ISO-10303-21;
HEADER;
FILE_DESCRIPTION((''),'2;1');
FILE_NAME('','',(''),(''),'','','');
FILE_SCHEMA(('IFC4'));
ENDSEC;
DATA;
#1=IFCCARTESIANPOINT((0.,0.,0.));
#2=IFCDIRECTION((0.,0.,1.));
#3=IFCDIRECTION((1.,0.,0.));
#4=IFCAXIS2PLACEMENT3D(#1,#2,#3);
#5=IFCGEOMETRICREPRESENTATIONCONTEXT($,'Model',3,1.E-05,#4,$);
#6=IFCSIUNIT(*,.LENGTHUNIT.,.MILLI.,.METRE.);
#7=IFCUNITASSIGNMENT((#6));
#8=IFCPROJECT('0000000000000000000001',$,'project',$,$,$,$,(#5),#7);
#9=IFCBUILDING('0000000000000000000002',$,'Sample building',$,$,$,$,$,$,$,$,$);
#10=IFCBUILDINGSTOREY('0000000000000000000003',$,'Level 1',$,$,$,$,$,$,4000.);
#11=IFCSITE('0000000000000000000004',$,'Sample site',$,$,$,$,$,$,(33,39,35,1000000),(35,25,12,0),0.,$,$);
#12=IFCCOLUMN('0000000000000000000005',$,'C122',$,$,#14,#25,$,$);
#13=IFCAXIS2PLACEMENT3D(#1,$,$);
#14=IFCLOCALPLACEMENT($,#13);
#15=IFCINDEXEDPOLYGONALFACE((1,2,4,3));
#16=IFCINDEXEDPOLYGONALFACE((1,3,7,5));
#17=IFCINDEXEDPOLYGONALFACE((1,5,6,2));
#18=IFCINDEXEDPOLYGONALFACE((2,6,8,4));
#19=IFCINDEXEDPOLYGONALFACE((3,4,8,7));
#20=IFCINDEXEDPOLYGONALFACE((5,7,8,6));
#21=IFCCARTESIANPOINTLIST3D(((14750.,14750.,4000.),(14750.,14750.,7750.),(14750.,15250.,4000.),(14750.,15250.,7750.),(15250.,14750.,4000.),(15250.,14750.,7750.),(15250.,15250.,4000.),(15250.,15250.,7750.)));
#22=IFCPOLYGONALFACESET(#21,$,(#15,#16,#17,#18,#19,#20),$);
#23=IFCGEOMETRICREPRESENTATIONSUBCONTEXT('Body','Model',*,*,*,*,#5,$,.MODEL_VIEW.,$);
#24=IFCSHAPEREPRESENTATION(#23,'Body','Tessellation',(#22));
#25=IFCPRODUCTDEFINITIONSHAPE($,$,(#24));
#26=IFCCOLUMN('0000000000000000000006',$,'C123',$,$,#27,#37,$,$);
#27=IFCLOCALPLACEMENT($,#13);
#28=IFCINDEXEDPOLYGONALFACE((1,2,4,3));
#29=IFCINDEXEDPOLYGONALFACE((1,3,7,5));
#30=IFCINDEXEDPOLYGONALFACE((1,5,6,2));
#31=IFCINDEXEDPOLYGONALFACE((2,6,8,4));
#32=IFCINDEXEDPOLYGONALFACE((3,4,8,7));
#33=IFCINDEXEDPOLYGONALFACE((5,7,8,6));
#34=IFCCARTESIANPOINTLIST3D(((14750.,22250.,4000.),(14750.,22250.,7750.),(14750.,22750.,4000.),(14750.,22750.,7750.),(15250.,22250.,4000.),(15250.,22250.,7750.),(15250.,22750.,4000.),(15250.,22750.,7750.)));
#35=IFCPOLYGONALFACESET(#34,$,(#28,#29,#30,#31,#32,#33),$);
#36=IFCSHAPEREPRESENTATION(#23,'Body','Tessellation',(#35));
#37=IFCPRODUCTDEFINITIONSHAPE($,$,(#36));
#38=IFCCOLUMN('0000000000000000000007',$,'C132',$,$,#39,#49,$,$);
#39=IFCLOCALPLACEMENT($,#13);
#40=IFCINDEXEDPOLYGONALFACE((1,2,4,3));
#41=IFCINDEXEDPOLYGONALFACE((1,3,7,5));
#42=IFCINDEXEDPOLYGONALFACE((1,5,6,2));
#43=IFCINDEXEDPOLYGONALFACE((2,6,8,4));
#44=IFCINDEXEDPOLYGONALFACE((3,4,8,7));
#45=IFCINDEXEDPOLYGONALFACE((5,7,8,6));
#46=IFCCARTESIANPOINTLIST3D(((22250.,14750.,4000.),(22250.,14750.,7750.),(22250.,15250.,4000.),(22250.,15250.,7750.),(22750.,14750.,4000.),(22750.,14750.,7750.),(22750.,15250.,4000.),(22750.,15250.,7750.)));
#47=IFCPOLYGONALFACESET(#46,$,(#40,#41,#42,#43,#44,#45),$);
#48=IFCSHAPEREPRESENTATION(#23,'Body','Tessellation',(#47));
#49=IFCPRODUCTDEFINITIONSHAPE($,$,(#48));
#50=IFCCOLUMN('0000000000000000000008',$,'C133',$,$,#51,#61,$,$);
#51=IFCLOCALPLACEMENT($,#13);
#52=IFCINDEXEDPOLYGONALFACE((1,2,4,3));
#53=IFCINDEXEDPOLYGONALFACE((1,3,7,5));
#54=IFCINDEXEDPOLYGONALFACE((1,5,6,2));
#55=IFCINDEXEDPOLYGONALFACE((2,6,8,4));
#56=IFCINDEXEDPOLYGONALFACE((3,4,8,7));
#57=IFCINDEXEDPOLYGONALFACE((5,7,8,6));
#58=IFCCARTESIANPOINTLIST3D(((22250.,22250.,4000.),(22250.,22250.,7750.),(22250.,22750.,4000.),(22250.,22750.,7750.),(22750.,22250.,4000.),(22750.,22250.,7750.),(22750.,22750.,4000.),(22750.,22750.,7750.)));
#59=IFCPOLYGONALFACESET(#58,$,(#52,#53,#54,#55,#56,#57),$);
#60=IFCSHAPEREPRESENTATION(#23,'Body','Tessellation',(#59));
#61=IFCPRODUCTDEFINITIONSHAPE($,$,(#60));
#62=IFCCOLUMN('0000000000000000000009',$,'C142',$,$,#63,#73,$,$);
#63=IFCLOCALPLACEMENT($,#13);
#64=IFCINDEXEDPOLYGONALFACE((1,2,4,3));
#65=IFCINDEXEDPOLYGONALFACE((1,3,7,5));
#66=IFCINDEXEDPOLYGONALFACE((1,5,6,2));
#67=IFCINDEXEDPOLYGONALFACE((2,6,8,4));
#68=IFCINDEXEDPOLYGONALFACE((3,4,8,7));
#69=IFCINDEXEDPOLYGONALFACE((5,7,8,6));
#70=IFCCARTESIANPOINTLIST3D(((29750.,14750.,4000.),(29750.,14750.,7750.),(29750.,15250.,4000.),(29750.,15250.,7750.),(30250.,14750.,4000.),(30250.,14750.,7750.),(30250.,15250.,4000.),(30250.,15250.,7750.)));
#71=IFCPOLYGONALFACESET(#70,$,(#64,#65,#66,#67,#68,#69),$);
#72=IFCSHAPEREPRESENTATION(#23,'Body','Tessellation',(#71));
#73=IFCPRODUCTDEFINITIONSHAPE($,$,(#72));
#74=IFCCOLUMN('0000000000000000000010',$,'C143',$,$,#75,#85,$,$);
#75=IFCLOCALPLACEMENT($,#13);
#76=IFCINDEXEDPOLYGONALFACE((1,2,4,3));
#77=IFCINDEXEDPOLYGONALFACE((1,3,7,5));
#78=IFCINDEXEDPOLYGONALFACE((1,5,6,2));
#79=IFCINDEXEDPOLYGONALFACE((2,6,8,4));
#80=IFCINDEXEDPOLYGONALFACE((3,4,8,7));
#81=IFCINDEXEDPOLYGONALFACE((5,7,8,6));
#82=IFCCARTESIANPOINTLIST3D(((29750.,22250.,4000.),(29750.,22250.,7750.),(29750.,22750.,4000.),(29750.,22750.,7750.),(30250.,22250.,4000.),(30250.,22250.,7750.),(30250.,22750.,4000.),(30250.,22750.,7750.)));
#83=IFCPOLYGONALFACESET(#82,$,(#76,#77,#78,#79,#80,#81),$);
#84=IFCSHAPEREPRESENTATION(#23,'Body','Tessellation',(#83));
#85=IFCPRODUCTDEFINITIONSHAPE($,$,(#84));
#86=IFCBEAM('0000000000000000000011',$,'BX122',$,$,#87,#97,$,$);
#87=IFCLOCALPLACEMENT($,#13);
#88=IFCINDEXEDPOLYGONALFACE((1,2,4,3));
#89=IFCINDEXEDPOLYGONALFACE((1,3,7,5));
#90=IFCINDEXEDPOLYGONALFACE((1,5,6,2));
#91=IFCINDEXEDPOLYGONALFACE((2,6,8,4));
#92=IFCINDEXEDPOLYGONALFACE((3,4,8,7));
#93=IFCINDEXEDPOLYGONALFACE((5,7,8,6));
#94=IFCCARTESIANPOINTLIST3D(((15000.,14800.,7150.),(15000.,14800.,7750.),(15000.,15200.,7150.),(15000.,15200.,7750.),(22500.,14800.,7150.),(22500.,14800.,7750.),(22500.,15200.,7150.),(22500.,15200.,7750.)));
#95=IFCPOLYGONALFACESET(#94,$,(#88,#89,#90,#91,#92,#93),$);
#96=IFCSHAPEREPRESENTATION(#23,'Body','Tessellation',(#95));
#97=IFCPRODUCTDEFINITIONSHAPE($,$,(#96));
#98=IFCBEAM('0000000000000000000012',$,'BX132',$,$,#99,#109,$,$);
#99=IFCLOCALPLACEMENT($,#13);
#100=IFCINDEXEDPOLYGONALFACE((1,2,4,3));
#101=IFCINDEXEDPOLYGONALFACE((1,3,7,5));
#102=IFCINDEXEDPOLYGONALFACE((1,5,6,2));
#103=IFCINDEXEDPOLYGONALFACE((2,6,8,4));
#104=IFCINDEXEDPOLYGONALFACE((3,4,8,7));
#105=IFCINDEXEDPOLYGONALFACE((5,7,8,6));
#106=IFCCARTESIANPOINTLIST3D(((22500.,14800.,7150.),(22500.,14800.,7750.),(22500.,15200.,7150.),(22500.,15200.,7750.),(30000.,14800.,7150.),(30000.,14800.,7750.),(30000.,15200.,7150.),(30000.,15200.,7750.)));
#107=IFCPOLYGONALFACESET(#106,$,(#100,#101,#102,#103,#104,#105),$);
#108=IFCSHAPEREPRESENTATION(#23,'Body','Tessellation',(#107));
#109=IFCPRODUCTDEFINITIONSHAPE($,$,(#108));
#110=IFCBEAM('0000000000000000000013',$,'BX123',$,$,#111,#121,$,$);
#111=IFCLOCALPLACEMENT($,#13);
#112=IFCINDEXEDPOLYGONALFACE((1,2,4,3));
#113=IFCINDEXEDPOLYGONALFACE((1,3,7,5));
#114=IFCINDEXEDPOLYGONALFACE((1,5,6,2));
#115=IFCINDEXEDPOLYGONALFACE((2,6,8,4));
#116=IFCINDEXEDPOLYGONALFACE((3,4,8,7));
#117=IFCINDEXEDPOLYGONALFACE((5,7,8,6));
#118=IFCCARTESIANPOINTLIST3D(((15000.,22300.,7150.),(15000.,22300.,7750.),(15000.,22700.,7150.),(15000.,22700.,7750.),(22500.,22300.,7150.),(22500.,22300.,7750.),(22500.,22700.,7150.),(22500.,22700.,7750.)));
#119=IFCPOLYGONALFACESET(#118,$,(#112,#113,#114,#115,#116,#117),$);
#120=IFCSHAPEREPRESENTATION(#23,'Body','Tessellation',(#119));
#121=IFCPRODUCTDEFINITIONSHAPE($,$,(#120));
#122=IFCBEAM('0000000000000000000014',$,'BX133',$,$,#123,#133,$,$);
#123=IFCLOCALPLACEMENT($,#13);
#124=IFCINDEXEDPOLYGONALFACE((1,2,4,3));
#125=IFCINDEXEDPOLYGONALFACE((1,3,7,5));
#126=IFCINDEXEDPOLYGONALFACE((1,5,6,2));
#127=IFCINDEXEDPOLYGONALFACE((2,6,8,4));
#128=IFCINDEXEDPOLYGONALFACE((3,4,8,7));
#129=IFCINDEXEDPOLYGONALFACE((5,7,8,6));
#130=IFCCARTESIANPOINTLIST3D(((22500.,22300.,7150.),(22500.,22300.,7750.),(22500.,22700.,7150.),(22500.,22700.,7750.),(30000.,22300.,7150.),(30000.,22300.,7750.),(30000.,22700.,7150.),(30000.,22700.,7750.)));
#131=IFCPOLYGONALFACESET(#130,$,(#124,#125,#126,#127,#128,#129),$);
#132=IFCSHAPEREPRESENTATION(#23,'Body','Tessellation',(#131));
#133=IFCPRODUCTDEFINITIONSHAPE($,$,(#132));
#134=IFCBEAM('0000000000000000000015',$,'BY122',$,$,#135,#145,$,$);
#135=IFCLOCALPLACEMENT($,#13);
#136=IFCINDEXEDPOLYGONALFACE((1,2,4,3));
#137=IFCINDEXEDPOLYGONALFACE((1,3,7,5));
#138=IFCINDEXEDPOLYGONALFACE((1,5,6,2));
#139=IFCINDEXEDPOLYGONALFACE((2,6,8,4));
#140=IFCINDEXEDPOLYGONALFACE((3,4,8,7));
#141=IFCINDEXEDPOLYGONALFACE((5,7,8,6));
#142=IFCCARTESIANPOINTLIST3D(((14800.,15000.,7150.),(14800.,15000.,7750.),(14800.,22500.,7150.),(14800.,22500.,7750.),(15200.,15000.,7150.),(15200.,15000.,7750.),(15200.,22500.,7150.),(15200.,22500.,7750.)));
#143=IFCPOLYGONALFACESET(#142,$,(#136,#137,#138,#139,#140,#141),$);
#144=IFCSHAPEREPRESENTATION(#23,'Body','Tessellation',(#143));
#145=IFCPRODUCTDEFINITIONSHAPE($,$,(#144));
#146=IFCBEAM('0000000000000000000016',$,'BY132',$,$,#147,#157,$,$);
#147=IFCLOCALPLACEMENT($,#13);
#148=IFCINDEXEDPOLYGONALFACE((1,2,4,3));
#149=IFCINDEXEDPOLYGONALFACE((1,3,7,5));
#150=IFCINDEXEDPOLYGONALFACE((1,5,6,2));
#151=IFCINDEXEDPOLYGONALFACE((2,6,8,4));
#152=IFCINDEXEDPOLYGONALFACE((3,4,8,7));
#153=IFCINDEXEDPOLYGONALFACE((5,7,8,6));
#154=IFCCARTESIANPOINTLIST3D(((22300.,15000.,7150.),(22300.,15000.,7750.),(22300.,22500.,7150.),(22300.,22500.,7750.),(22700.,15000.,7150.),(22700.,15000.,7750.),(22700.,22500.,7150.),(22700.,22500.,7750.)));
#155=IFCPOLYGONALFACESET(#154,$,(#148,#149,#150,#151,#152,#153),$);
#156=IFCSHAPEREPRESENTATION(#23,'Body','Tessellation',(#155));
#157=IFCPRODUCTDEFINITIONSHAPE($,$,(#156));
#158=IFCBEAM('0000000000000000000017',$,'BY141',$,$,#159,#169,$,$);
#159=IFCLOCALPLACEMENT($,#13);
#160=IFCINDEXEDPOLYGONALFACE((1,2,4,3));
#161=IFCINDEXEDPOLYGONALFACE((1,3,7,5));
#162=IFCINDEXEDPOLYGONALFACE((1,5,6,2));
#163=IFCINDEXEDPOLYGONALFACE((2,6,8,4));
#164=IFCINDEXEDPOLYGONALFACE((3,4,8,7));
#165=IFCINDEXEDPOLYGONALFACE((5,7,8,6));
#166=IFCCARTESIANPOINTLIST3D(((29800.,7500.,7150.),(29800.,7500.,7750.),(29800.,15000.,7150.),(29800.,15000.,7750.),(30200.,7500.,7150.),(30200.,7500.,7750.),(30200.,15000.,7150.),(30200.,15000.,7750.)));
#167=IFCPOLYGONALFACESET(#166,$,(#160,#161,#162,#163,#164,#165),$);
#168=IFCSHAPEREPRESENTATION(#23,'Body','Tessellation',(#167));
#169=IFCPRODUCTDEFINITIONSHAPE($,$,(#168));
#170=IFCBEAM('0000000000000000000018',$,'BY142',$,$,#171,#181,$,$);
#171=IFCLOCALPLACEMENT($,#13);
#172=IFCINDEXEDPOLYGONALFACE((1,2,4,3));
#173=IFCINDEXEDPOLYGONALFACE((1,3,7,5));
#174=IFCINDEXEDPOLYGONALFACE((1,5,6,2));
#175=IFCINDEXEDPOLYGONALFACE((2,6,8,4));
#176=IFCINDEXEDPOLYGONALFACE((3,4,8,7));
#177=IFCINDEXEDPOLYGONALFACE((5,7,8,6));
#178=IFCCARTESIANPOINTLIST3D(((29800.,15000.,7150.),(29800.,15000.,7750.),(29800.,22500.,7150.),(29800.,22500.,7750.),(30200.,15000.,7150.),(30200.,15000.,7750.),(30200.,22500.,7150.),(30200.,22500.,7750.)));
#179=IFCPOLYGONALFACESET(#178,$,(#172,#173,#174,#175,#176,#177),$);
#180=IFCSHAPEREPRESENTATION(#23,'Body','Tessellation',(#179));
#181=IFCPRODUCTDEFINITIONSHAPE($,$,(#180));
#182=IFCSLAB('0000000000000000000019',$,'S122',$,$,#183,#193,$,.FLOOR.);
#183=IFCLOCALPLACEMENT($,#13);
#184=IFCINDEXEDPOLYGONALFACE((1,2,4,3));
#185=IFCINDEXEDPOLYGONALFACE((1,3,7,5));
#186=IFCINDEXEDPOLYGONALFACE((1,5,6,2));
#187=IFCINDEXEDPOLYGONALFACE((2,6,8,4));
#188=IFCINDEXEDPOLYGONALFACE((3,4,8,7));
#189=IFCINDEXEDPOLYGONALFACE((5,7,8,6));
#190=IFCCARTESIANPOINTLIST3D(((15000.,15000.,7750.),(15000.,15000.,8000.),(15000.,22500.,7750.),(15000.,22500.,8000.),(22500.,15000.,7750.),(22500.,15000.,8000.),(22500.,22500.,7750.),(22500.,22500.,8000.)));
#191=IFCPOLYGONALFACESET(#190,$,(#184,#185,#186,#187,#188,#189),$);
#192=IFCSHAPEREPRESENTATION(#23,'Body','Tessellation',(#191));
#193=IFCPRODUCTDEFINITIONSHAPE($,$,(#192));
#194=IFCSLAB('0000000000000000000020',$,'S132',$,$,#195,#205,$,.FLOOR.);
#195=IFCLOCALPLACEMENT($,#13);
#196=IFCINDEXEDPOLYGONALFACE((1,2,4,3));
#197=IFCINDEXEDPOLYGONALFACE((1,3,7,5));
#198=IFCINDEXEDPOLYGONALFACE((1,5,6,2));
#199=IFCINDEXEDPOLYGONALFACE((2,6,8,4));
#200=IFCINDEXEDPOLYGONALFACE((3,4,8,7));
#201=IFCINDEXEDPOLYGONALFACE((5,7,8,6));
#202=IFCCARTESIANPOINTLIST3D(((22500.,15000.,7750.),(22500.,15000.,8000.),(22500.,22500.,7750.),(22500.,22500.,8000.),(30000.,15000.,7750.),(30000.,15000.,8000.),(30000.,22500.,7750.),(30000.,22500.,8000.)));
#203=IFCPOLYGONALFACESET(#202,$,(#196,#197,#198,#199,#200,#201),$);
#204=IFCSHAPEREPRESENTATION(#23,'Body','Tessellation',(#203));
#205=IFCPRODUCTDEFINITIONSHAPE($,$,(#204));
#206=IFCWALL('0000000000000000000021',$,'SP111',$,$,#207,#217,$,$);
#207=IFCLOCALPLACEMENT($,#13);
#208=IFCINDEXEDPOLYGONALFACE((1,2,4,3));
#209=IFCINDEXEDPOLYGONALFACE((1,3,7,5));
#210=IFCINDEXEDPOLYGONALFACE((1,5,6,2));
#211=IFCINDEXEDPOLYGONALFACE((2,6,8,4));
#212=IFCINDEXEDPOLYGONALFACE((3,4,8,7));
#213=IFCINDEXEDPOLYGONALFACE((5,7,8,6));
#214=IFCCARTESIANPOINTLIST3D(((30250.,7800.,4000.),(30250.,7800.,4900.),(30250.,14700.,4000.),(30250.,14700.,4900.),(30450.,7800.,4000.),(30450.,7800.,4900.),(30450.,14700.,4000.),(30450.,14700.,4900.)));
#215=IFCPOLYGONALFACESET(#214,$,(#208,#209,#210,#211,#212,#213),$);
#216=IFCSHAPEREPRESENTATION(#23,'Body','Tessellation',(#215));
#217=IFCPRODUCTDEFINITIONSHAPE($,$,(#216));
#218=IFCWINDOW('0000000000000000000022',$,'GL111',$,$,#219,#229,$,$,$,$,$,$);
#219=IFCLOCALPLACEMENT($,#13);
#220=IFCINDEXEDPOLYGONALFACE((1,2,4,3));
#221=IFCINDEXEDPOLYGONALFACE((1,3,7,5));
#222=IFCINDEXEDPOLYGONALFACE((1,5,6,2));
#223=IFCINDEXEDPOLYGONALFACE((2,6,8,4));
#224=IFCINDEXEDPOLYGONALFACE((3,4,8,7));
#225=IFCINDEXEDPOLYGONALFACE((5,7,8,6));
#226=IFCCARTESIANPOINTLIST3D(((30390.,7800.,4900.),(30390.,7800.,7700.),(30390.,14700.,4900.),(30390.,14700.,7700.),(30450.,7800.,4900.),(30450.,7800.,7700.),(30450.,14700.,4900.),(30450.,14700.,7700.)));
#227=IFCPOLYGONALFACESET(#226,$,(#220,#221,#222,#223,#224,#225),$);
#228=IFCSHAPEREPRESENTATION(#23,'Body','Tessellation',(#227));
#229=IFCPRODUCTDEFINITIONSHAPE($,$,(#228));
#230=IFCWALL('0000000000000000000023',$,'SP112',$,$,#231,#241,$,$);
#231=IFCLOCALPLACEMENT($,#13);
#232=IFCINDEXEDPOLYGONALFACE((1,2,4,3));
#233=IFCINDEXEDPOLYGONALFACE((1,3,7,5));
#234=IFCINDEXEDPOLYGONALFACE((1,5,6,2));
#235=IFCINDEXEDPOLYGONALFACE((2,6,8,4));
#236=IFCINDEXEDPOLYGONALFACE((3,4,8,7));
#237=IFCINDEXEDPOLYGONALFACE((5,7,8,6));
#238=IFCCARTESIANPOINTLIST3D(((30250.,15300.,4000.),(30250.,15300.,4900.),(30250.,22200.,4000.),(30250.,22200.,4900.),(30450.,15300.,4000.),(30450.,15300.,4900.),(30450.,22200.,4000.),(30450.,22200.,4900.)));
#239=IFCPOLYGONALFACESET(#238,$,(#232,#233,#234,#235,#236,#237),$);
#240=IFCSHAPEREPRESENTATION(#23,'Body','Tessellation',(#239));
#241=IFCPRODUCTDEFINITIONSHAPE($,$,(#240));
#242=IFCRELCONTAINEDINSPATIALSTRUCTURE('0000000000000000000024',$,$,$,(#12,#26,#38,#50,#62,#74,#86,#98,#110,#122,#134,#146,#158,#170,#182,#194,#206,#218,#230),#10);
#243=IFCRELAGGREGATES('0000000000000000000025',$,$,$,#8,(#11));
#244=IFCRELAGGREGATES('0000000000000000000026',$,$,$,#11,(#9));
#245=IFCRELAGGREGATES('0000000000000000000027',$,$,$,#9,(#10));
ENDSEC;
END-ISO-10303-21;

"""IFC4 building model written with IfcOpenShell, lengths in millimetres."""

from ifc_helpers import new_model, si_unit, frame, origin_with_axes, place, context, subcontext, project, spatial, indexed_curve, outline, extrude, element, save


model = new_model("IFC4")

# Units and contexts
model_context = context("Model", 3, precision=1e-05, world=origin_with_axes())
body_context = subcontext(model_context, "Body", "Model", "MODEL_VIEW")
ifc_project = project(units=[si_unit("LENGTHUNIT", "METRE", prefix="MILLI")], contexts=[model_context])

# Site, building, storey
site = spatial("IfcSite", under=ifc_project, Name="Sample site", RefLatitude=(33, 39, 35, 1000000), RefLongitude=(35, 25, 12, 0), RefElevation=0.0)
building = spatial("IfcBuilding", under=site, Name="Sample building")
storey = spatial("IfcBuildingStorey", under=building, Name="Level 1", Elevation=4000.0)

# Columns
for number, where, z_axis, x_axis, name in (
    (1, (14750.0, 14750.0, 4000.0), (0.0, 0.0, 1.0), (1.0, 0.0, 0.0), "C122"),
    (2, (14750.0, 22250.0, 4000.0), (0.0, 0.0, 1.0), (1.0, 0.0, 0.0), "C123"),
    (3, (22250.0, 14750.0, 4000.0), (0.0, 0.0, 1.0), (1.0, 0.0, 0.0), "C132"),
    (4, (22250.0, 22250.0, 4000.0), (0.0, 0.0, 1.0), (1.0, 0.0, 0.0), "C133"),
    (5, (29750.0, 14750.0, 4000.0), (0.0, 0.0, 1.0), (1.0, 0.0, 0.0), "C142"),
    (6, (29750.0, 22250.0, 4000.0), (0.0, 0.0, 1.0), (1.0, 0.0, 0.0), "C143"),
):
    element("IfcColumn", number, at=place(None, frame(where, z_axis=z_axis, x_axis=x_axis)), inside=storey, Name=name, context=body_context, shape_type="SweptSolid", body=[
        extrude(outline(indexed_curve([(0.0, 0.0), (0.0, 500.0), (500.0, 500.0), (500.0, 0.0), (0.0, 0.0)], self_intersect=False)), origin_with_axes(), (0.0, 0.0, 1.0), 3750.0),
    ])

# Beams
for number, where, z_axis, x_axis, name in (
    (7, (15000.0, 14800.0, 7150.0), (0.0, 0.0, 1.0), (1.0, 0.0, 0.0), "BX122"),
    (8, (22500.0, 14800.0, 7150.0), (0.0, 0.0, 1.0), (1.0, 0.0, 0.0), "BX132"),
    (9, (15000.0, 22300.0, 7150.0), (0.0, 0.0, 1.0), (1.0, 0.0, 0.0), "BX123"),
    (10, (22500.0, 22300.0, 7150.0), (0.0, 0.0, 1.0), (1.0, 0.0, 0.0), "BX133"),
    (11, (15200.0, 15000.0, 7150.0), (0.0, 0.0, 1.0), (0.0, 1.0, 0.0), "BY122"),
    (12, (22700.0, 15000.0, 7150.0), (0.0, 0.0, 1.0), (0.0, 1.0, 0.0), "BY132"),
    (13, (30200.0, 7500.0, 7150.0), (0.0, 0.0, 1.0), (0.0, 1.0, 0.0), "BY141"),
    (14, (30200.0, 15000.0, 7150.0), (0.0, 0.0, 1.0), (0.0, 1.0, 0.0), "BY142"),
):
    element("IfcBeam", number, at=place(None, frame(where, z_axis=z_axis, x_axis=x_axis)), inside=storey, Name=name, context=body_context, shape_type="SweptSolid", body=[
        extrude(outline(indexed_curve([(0.0, 0.0), (0.0, 400.0), (7500.0, 400.0), (7500.0, 0.0), (0.0, 0.0)], self_intersect=False)), origin_with_axes(), (0.0, 0.0, 1.0), 600.0),
    ])

# Slabs
for number, where, z_axis, x_axis, name in (
    (15, (15000.0, 15000.0, 7750.0), (0.0, 0.0, 1.0), (1.0, 0.0, 0.0), "S122"),
    (16, (22500.0, 15000.0, 7750.0), (0.0, 0.0, 1.0), (1.0, 0.0, 0.0), "S132"),
):
    element("IfcSlab", number, at=place(None, frame(where, z_axis=z_axis, x_axis=x_axis)), inside=storey, Name=name, PredefinedType="FLOOR", context=body_context, shape_type="SweptSolid", body=[
        extrude(outline(indexed_curve([(0.0, 0.0), (0.0, 7500.0), (7500.0, 7500.0), (7500.0, 0.0), (0.0, 0.0)], self_intersect=False)), origin_with_axes(), (0.0, 0.0, 1.0), 250.0),
    ])

# Wall
wall_1_placement = place(None, frame((30450.0, 7800.0, 4000.0), z_axis=(0.0, 0.0, 1.0), x_axis=(0.0, 1.0, 0.0)))
element("IfcWall", 17, at=wall_1_placement, inside=storey, Name="SP111", context=body_context, shape_type="SweptSolid", body=[
    extrude(outline(indexed_curve([(0.0, 0.0), (0.0, 200.0), (6900.0, 200.0), (6900.0, 0.0), (0.0, 0.0)], self_intersect=False)), origin_with_axes(), (0.0, 0.0, 1.0), 900.0),
])

# Window
window_1_placement = place(None, frame((30450.0, 7800.0, 4900.0), z_axis=(0.0, 0.0, 1.0), x_axis=(0.0, 1.0, 0.0)))
element("IfcWindow", 18, at=window_1_placement, inside=storey, Name="GL111", context=body_context, shape_type="SweptSolid", body=[
    extrude(outline(indexed_curve([(0.0, 0.0), (0.0, 60.0), (6900.0, 60.0), (6900.0, 0.0), (0.0, 0.0)], self_intersect=False)), origin_with_axes(), (0.0, 0.0, 1.0), 2800.0),
])

# Wall
wall_2_placement = place(None, frame((30450.0, 15300.0, 4000.0), z_axis=(0.0, 0.0, 1.0), x_axis=(0.0, 1.0, 0.0)))
element("IfcWall", 19, at=wall_2_placement, inside=storey, Name="SP112", context=body_context, shape_type="SweptSolid", body=[
    extrude(outline(indexed_curve([(0.0, 0.0), (0.0, 200.0), (6900.0, 200.0), (6900.0, 0.0), (0.0, 0.0)], self_intersect=False)), origin_with_axes(), (0.0, 0.0, 1.0), 900.0),
])

save(model, "model.ifc")
